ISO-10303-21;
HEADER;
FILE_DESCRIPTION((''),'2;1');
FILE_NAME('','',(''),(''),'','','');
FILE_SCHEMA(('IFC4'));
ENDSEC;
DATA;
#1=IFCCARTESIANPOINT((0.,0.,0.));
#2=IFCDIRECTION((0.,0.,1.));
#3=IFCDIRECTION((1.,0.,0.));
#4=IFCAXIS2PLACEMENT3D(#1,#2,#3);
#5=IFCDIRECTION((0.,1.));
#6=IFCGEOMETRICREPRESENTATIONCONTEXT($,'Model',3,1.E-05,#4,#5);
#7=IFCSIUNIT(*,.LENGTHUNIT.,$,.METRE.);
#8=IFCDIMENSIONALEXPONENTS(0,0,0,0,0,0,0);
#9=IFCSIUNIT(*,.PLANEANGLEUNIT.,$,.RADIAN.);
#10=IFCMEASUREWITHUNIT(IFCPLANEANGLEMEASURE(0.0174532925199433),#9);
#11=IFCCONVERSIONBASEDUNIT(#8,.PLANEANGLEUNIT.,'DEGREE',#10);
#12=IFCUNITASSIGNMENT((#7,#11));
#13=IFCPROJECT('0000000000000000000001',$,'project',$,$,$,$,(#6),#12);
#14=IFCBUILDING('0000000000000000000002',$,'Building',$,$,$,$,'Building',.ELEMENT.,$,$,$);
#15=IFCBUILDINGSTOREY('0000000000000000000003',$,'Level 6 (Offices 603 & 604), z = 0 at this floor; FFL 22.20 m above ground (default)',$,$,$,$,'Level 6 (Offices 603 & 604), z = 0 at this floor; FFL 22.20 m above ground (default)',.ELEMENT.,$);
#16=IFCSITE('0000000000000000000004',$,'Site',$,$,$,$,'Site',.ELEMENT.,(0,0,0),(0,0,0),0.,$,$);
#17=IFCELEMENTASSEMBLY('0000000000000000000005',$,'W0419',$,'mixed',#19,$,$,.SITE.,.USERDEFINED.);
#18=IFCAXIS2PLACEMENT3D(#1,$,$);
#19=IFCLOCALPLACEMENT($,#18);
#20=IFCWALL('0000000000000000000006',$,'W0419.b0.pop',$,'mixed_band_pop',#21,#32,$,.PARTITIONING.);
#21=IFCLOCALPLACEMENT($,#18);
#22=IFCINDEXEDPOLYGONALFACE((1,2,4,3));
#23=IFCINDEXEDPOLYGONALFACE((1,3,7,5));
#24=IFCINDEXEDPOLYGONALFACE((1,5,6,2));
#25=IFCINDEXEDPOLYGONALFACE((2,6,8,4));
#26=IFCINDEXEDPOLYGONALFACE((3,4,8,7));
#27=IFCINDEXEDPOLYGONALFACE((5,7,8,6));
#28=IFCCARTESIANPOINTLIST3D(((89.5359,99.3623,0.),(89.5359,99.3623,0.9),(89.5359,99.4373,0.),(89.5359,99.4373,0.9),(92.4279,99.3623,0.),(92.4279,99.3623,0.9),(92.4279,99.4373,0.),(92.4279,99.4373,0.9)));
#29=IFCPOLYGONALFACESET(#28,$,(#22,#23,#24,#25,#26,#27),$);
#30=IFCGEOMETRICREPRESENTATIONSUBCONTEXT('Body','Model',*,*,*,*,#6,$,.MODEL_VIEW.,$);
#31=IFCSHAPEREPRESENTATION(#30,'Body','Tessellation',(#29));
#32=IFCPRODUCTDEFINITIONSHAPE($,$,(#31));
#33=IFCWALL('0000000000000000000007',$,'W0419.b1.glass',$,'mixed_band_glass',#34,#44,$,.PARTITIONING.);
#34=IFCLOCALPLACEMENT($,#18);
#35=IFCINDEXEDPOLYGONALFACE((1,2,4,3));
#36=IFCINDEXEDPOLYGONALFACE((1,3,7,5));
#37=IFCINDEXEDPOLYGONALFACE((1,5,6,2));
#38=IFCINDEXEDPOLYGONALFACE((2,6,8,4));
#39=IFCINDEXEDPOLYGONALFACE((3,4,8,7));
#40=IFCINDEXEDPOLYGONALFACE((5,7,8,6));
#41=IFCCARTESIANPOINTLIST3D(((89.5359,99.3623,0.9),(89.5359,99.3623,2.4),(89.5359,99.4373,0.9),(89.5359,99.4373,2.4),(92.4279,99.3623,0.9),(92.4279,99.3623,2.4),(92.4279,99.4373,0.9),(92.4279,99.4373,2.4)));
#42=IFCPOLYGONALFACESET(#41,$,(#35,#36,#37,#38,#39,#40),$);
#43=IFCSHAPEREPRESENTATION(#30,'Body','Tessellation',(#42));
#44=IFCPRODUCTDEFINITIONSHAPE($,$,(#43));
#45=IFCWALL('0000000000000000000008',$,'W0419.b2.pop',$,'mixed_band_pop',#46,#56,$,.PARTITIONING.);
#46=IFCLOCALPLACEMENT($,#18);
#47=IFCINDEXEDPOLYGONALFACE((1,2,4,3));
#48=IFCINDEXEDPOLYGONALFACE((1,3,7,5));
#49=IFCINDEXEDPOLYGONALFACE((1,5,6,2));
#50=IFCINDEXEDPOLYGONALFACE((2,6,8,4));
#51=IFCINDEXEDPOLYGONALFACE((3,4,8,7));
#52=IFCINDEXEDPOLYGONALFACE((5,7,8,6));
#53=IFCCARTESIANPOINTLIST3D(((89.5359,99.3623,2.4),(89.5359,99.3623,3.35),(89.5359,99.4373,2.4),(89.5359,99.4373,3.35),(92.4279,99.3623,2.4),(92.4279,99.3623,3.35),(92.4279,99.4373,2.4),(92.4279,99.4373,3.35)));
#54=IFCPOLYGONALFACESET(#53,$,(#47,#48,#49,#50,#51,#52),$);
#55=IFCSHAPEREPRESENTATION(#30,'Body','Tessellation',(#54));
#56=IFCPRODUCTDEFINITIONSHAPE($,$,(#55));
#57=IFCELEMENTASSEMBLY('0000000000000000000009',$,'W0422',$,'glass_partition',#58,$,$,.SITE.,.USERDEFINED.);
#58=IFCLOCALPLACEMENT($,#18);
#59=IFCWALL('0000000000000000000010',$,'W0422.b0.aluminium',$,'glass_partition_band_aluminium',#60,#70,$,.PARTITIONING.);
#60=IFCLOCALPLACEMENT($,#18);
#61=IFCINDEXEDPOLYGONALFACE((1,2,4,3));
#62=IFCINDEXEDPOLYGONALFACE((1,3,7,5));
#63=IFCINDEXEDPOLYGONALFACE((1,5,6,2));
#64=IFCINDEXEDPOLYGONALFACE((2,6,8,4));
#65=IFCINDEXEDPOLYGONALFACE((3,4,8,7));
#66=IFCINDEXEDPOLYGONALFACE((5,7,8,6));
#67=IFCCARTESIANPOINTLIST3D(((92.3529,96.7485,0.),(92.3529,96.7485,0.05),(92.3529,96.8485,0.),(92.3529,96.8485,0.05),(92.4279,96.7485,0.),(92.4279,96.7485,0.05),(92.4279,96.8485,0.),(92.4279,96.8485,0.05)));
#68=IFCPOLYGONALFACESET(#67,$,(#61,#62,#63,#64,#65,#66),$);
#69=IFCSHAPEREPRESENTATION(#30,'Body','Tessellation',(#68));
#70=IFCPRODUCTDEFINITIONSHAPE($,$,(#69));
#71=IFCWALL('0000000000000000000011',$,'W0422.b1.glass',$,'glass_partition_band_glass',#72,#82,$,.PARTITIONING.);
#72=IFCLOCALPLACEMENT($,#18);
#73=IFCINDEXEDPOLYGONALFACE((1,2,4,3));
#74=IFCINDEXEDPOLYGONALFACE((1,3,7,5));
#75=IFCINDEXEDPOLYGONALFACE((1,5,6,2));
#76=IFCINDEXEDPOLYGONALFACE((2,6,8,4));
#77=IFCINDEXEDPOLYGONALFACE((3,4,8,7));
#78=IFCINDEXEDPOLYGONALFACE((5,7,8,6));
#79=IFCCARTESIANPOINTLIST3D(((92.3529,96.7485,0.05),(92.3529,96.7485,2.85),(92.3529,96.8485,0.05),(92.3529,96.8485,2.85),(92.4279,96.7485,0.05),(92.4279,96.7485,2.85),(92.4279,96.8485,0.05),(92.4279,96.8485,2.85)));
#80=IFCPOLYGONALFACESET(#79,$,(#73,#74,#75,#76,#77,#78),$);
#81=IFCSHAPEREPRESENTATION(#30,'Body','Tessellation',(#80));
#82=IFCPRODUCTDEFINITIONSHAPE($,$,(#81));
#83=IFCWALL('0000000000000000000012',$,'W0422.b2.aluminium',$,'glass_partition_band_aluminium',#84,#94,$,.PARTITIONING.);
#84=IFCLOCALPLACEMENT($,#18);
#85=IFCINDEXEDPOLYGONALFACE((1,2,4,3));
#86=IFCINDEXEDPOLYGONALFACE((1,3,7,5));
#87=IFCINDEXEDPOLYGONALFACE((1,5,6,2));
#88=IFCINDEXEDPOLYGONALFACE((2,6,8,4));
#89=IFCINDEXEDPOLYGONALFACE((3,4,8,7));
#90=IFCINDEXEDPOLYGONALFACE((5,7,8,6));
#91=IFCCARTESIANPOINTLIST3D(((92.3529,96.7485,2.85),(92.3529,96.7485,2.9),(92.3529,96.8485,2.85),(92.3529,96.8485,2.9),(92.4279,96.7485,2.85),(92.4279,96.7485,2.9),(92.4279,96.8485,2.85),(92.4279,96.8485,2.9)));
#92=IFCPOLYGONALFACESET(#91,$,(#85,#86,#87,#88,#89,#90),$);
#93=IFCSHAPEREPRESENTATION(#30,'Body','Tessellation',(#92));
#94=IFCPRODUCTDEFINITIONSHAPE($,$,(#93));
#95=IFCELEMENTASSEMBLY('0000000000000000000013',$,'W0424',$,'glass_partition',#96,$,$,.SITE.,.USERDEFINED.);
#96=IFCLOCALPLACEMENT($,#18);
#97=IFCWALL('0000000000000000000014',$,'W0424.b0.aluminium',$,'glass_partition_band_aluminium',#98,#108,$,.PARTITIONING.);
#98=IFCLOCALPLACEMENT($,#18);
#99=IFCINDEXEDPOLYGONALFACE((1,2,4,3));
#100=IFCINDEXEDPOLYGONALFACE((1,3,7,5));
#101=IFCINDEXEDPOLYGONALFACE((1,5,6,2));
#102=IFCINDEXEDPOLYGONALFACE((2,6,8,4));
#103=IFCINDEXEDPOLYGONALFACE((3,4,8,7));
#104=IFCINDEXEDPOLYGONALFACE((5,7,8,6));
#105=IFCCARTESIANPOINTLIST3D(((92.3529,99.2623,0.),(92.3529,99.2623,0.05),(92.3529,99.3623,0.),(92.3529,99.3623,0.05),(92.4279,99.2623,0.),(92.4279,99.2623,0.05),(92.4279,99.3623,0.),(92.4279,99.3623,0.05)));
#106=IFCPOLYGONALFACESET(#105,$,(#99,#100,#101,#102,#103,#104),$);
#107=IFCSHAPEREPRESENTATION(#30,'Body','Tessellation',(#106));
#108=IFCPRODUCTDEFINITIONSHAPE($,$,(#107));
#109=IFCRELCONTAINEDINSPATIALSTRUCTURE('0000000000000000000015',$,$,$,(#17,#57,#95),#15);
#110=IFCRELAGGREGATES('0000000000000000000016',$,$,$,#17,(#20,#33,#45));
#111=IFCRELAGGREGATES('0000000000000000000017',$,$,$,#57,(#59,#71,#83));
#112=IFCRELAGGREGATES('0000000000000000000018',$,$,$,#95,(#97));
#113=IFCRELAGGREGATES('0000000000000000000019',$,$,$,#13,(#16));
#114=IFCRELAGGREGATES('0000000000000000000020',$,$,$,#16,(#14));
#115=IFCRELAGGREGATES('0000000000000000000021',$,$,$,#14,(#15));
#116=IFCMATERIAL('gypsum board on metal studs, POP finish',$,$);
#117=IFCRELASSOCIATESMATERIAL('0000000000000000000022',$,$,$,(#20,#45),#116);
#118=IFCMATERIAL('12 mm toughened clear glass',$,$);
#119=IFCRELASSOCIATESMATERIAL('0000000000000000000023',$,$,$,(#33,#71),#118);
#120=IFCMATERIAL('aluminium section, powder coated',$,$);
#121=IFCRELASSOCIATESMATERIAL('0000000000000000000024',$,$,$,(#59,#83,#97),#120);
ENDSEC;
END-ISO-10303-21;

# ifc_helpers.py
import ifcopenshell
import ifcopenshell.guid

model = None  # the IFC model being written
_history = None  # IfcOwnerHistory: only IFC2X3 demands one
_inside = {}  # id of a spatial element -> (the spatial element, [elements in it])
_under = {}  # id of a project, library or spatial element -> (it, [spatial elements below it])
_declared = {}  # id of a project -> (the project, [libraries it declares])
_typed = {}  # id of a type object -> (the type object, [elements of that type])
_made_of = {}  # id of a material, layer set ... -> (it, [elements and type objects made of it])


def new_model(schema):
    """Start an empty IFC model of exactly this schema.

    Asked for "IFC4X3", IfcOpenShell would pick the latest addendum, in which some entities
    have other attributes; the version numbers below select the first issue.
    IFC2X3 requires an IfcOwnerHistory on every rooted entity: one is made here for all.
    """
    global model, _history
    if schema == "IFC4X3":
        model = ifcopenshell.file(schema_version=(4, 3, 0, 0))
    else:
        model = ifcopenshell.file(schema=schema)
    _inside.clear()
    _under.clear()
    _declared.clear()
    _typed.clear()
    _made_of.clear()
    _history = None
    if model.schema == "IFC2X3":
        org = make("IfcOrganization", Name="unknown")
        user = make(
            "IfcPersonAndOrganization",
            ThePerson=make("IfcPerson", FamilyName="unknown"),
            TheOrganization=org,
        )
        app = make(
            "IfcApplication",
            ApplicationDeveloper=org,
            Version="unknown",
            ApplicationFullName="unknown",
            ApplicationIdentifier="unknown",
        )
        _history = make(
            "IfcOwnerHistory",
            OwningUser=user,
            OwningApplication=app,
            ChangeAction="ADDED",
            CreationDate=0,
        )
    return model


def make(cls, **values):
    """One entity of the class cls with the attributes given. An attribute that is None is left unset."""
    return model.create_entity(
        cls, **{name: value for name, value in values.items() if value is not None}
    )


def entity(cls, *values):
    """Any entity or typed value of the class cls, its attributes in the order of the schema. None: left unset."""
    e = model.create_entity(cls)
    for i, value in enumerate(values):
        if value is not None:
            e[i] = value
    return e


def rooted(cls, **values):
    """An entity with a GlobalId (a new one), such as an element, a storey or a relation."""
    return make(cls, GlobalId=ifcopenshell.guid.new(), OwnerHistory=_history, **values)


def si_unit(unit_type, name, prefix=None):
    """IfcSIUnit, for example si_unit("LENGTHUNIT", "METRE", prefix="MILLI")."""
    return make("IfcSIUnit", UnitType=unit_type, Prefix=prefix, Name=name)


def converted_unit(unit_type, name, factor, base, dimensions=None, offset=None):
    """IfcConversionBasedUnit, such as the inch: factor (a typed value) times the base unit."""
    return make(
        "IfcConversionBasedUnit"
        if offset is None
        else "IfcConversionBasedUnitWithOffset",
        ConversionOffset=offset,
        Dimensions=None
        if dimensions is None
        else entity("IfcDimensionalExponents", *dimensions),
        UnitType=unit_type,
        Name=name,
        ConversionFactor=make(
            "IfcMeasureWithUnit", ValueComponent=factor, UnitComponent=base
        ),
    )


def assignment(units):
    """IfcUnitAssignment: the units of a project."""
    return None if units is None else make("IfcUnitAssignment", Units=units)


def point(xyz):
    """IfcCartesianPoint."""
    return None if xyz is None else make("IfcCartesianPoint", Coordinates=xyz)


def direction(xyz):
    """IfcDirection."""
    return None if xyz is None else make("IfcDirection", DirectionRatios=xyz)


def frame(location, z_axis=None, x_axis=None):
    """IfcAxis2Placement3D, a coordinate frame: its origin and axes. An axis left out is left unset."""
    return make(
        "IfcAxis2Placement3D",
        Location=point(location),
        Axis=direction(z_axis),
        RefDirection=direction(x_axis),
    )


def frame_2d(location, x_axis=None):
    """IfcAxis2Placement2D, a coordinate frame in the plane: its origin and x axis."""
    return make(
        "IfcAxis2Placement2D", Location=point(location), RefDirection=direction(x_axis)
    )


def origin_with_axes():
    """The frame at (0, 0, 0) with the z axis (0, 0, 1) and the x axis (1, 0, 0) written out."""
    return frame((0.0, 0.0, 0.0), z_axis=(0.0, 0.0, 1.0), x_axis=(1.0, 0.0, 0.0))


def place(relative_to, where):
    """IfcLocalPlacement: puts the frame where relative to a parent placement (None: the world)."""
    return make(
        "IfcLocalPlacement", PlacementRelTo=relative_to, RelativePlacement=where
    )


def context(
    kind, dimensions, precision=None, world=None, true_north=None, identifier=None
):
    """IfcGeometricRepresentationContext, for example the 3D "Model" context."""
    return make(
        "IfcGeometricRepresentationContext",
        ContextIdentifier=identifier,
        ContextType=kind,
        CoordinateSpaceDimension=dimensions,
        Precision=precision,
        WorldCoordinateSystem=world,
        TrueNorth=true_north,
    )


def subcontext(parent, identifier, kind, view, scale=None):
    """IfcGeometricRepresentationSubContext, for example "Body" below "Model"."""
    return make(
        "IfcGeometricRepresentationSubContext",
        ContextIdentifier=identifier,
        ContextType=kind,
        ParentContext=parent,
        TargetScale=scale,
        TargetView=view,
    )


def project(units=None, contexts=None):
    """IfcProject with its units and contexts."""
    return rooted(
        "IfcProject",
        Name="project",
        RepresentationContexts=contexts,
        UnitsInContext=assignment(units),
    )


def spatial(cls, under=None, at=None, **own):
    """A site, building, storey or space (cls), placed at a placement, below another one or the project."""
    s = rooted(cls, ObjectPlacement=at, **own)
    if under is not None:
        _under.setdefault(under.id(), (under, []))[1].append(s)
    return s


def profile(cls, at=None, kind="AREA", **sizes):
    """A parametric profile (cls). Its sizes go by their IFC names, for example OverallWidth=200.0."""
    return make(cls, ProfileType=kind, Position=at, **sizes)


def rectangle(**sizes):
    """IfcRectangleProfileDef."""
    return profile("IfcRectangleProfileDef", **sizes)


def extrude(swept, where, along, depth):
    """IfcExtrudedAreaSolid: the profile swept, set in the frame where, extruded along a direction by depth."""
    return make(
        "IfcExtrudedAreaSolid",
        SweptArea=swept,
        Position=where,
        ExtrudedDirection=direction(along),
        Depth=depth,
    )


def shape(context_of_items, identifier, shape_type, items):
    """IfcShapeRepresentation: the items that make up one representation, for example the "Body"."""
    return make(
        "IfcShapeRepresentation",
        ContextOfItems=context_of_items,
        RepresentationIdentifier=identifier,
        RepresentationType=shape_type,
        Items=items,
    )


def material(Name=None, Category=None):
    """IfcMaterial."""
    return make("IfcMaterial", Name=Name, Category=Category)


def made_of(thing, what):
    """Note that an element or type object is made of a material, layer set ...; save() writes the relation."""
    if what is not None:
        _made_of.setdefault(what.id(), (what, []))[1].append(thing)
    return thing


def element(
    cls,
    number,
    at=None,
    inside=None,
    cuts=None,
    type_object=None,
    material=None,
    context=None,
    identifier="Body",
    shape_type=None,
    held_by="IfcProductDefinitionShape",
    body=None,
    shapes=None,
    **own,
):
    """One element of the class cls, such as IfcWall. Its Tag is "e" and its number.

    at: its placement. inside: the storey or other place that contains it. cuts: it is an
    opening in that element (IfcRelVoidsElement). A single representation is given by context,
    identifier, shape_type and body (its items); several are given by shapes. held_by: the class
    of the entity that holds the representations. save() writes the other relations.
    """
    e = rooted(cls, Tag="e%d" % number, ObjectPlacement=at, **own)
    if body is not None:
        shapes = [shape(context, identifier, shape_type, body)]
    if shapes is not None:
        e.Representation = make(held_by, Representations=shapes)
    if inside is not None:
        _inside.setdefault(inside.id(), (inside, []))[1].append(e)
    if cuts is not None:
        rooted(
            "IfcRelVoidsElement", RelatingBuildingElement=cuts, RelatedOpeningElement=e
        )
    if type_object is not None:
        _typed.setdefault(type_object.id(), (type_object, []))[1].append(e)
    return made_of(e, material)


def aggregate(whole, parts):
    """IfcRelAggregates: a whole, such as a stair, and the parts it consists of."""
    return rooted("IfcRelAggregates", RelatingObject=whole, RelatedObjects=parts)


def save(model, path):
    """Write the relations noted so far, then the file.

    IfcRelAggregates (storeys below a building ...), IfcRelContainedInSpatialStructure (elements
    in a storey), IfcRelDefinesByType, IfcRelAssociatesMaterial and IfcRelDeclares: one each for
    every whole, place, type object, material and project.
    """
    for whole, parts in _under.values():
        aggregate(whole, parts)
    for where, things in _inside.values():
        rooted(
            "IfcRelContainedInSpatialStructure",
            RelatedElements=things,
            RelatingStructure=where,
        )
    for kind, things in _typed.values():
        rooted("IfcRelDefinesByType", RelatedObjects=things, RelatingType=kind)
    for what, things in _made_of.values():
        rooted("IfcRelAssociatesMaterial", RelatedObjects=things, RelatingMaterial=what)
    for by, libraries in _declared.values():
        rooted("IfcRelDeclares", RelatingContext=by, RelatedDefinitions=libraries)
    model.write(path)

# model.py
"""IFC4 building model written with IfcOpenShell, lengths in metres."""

from ifc_helpers import new_model, entity, si_unit, converted_unit, direction, frame, frame_2d, origin_with_axes, place, context, subcontext, project, spatial, rectangle, extrude, material, element, aggregate, save


model = new_model("IFC4")

# Units and contexts
model_context = context("Model", 3, precision=1e-05, world=origin_with_axes(), true_north=direction((0.0, 1.0)))
body_context = subcontext(model_context, "Body", "Model", "MODEL_VIEW")
ifc_project = project(units=[si_unit("LENGTHUNIT", "METRE"), converted_unit("PLANEANGLEUNIT", "DEGREE", entity("IfcPlaneAngleMeasure", 0.0174532925199433), si_unit("PLANEANGLEUNIT", "RADIAN"), dimensions=[0, 0, 0, 0, 0, 0, 0])], contexts=[model_context])

# Site, building, storey
site = spatial("IfcSite", under=ifc_project, Name="Site", LongName="Site", CompositionType="ELEMENT", RefLatitude=(0, 0, 0), RefLongitude=(0, 0, 0), RefElevation=0.0)
building = spatial("IfcBuilding", under=site, Name="Building", LongName="Building", CompositionType="ELEMENT")
storey = spatial("IfcBuildingStorey", under=building, Name="Level 6 (Offices 603 & 604), z = 0 at this floor; FFL 22.20 m above ground (default)", LongName="Level 6 (Offices 603 & 604), z = 0 at this floor; FFL 22.20 m above ground (default)", CompositionType="ELEMENT")

# Shared definitions
ifc_material_1 = material(Name="aluminium section, powder coated")
placement = place(None, origin_with_axes())

# Shared definitions
ifc_material_2 = material(Name="12 mm toughened clear glass")

# Element assemblies, walls
ifc_material_3 = material(Name="gypsum board on metal studs, POP finish")
assembly_1 = element("IfcElementAssembly", 1, inside=storey, Name="W0419", ObjectType="mixed", AssemblyPlace="SITE", PredefinedType="USERDEFINED")
wall_1 = element("IfcWall", 2, at=placement, material=ifc_material_3, Name="W0419.b0.pop", ObjectType="mixed_band_pop", PredefinedType="PARTITIONING", context=body_context, shape_type="SweptSolid", body=[
    extrude(rectangle(XDim=2.892, YDim=0.075, at=frame_2d((0.0, 0.0), x_axis=(1.0, 0.0))), frame((90.9819, 99.3998, 0.0), z_axis=(0.0, 0.0, 1.0), x_axis=(1.0, 0.0, 0.0)), (0.0, 0.0, 1.0), 0.9),
])
wall_2 = element("IfcWall", 3, at=placement, material=ifc_material_2, Name="W0419.b1.glass", ObjectType="mixed_band_glass", PredefinedType="PARTITIONING", context=body_context, shape_type="SweptSolid", body=[
    extrude(rectangle(XDim=2.892, YDim=0.075, at=frame_2d((0.0, 0.0), x_axis=(1.0, 0.0))), frame((90.9819, 99.3998, 0.9), z_axis=(0.0, 0.0, 1.0), x_axis=(1.0, 0.0, 0.0)), (0.0, 0.0, 1.0), 1.5),
])
wall_3 = element("IfcWall", 4, at=placement, material=ifc_material_3, Name="W0419.b2.pop", ObjectType="mixed_band_pop", PredefinedType="PARTITIONING", context=body_context, shape_type="SweptSolid", body=[
    extrude(rectangle(XDim=2.892, YDim=0.075, at=frame_2d((0.0, 0.0), x_axis=(1.0, 0.0))), frame((90.9819, 99.3998, 2.4), z_axis=(0.0, 0.0, 1.0), x_axis=(1.0, 0.0, 0.0)), (0.0, 0.0, 1.0), 0.95),
])
aggregate(assembly_1, [wall_1, wall_2, wall_3])
assembly_2 = element("IfcElementAssembly", 5, inside=storey, Name="W0422", ObjectType="glass_partition", AssemblyPlace="SITE", PredefinedType="USERDEFINED")
wall_4 = element("IfcWall", 6, at=placement, material=ifc_material_1, Name="W0422.b0.aluminium", ObjectType="glass_partition_band_aluminium", PredefinedType="PARTITIONING", context=body_context, shape_type="SweptSolid", body=[
    extrude(rectangle(XDim=0.1, YDim=0.075, at=frame_2d((0.0, 0.0), x_axis=(0.0, 1.0))), frame((92.3904, 96.7985, 0.0), z_axis=(0.0, 0.0, 1.0), x_axis=(1.0, 0.0, 0.0)), (0.0, 0.0, 1.0), 0.05),
])
wall_5 = element("IfcWall", 7, at=placement, material=ifc_material_2, Name="W0422.b1.glass", ObjectType="glass_partition_band_glass", PredefinedType="PARTITIONING", context=body_context, shape_type="SweptSolid", body=[
    extrude(rectangle(XDim=0.1, YDim=0.075, at=frame_2d((0.0, 0.0), x_axis=(0.0, 1.0))), frame((92.3904, 96.7985, 0.05), z_axis=(0.0, 0.0, 1.0), x_axis=(1.0, 0.0, 0.0)), (0.0, 0.0, 1.0), 2.8),
])
wall_6 = element("IfcWall", 8, at=placement, material=ifc_material_1, Name="W0422.b2.aluminium", ObjectType="glass_partition_band_aluminium", PredefinedType="PARTITIONING", context=body_context, shape_type="SweptSolid", body=[
    extrude(rectangle(XDim=0.1, YDim=0.075, at=frame_2d((0.0, 0.0), x_axis=(0.0, 1.0))), frame((92.3904, 96.7985, 2.85), z_axis=(0.0, 0.0, 1.0), x_axis=(1.0, 0.0, 0.0)), (0.0, 0.0, 1.0), 0.05),
])
aggregate(assembly_2, [wall_4, wall_5, wall_6])

# Element assembly, wall
assembly_3 = element("IfcElementAssembly", 9, inside=storey, Name="W0424", ObjectType="glass_partition", AssemblyPlace="SITE", PredefinedType="USERDEFINED")
wall_7 = element("IfcWall", 10, at=placement, material=ifc_material_1, Name="W0424.b0.aluminium", ObjectType="glass_partition_band_aluminium", PredefinedType="PARTITIONING", context=body_context, shape_type="SweptSolid", body=[
    extrude(rectangle(XDim=0.1, YDim=0.075, at=frame_2d((0.0, 0.0), x_axis=(0.0, 1.0))), frame((92.3904, 99.3123, 0.0), z_axis=(0.0, 0.0, 1.0), x_axis=(1.0, 0.0, 0.0)), (0.0, 0.0, 1.0), 0.05),
])
aggregate(assembly_3, [wall_7])

save(model, "model.ifc")
